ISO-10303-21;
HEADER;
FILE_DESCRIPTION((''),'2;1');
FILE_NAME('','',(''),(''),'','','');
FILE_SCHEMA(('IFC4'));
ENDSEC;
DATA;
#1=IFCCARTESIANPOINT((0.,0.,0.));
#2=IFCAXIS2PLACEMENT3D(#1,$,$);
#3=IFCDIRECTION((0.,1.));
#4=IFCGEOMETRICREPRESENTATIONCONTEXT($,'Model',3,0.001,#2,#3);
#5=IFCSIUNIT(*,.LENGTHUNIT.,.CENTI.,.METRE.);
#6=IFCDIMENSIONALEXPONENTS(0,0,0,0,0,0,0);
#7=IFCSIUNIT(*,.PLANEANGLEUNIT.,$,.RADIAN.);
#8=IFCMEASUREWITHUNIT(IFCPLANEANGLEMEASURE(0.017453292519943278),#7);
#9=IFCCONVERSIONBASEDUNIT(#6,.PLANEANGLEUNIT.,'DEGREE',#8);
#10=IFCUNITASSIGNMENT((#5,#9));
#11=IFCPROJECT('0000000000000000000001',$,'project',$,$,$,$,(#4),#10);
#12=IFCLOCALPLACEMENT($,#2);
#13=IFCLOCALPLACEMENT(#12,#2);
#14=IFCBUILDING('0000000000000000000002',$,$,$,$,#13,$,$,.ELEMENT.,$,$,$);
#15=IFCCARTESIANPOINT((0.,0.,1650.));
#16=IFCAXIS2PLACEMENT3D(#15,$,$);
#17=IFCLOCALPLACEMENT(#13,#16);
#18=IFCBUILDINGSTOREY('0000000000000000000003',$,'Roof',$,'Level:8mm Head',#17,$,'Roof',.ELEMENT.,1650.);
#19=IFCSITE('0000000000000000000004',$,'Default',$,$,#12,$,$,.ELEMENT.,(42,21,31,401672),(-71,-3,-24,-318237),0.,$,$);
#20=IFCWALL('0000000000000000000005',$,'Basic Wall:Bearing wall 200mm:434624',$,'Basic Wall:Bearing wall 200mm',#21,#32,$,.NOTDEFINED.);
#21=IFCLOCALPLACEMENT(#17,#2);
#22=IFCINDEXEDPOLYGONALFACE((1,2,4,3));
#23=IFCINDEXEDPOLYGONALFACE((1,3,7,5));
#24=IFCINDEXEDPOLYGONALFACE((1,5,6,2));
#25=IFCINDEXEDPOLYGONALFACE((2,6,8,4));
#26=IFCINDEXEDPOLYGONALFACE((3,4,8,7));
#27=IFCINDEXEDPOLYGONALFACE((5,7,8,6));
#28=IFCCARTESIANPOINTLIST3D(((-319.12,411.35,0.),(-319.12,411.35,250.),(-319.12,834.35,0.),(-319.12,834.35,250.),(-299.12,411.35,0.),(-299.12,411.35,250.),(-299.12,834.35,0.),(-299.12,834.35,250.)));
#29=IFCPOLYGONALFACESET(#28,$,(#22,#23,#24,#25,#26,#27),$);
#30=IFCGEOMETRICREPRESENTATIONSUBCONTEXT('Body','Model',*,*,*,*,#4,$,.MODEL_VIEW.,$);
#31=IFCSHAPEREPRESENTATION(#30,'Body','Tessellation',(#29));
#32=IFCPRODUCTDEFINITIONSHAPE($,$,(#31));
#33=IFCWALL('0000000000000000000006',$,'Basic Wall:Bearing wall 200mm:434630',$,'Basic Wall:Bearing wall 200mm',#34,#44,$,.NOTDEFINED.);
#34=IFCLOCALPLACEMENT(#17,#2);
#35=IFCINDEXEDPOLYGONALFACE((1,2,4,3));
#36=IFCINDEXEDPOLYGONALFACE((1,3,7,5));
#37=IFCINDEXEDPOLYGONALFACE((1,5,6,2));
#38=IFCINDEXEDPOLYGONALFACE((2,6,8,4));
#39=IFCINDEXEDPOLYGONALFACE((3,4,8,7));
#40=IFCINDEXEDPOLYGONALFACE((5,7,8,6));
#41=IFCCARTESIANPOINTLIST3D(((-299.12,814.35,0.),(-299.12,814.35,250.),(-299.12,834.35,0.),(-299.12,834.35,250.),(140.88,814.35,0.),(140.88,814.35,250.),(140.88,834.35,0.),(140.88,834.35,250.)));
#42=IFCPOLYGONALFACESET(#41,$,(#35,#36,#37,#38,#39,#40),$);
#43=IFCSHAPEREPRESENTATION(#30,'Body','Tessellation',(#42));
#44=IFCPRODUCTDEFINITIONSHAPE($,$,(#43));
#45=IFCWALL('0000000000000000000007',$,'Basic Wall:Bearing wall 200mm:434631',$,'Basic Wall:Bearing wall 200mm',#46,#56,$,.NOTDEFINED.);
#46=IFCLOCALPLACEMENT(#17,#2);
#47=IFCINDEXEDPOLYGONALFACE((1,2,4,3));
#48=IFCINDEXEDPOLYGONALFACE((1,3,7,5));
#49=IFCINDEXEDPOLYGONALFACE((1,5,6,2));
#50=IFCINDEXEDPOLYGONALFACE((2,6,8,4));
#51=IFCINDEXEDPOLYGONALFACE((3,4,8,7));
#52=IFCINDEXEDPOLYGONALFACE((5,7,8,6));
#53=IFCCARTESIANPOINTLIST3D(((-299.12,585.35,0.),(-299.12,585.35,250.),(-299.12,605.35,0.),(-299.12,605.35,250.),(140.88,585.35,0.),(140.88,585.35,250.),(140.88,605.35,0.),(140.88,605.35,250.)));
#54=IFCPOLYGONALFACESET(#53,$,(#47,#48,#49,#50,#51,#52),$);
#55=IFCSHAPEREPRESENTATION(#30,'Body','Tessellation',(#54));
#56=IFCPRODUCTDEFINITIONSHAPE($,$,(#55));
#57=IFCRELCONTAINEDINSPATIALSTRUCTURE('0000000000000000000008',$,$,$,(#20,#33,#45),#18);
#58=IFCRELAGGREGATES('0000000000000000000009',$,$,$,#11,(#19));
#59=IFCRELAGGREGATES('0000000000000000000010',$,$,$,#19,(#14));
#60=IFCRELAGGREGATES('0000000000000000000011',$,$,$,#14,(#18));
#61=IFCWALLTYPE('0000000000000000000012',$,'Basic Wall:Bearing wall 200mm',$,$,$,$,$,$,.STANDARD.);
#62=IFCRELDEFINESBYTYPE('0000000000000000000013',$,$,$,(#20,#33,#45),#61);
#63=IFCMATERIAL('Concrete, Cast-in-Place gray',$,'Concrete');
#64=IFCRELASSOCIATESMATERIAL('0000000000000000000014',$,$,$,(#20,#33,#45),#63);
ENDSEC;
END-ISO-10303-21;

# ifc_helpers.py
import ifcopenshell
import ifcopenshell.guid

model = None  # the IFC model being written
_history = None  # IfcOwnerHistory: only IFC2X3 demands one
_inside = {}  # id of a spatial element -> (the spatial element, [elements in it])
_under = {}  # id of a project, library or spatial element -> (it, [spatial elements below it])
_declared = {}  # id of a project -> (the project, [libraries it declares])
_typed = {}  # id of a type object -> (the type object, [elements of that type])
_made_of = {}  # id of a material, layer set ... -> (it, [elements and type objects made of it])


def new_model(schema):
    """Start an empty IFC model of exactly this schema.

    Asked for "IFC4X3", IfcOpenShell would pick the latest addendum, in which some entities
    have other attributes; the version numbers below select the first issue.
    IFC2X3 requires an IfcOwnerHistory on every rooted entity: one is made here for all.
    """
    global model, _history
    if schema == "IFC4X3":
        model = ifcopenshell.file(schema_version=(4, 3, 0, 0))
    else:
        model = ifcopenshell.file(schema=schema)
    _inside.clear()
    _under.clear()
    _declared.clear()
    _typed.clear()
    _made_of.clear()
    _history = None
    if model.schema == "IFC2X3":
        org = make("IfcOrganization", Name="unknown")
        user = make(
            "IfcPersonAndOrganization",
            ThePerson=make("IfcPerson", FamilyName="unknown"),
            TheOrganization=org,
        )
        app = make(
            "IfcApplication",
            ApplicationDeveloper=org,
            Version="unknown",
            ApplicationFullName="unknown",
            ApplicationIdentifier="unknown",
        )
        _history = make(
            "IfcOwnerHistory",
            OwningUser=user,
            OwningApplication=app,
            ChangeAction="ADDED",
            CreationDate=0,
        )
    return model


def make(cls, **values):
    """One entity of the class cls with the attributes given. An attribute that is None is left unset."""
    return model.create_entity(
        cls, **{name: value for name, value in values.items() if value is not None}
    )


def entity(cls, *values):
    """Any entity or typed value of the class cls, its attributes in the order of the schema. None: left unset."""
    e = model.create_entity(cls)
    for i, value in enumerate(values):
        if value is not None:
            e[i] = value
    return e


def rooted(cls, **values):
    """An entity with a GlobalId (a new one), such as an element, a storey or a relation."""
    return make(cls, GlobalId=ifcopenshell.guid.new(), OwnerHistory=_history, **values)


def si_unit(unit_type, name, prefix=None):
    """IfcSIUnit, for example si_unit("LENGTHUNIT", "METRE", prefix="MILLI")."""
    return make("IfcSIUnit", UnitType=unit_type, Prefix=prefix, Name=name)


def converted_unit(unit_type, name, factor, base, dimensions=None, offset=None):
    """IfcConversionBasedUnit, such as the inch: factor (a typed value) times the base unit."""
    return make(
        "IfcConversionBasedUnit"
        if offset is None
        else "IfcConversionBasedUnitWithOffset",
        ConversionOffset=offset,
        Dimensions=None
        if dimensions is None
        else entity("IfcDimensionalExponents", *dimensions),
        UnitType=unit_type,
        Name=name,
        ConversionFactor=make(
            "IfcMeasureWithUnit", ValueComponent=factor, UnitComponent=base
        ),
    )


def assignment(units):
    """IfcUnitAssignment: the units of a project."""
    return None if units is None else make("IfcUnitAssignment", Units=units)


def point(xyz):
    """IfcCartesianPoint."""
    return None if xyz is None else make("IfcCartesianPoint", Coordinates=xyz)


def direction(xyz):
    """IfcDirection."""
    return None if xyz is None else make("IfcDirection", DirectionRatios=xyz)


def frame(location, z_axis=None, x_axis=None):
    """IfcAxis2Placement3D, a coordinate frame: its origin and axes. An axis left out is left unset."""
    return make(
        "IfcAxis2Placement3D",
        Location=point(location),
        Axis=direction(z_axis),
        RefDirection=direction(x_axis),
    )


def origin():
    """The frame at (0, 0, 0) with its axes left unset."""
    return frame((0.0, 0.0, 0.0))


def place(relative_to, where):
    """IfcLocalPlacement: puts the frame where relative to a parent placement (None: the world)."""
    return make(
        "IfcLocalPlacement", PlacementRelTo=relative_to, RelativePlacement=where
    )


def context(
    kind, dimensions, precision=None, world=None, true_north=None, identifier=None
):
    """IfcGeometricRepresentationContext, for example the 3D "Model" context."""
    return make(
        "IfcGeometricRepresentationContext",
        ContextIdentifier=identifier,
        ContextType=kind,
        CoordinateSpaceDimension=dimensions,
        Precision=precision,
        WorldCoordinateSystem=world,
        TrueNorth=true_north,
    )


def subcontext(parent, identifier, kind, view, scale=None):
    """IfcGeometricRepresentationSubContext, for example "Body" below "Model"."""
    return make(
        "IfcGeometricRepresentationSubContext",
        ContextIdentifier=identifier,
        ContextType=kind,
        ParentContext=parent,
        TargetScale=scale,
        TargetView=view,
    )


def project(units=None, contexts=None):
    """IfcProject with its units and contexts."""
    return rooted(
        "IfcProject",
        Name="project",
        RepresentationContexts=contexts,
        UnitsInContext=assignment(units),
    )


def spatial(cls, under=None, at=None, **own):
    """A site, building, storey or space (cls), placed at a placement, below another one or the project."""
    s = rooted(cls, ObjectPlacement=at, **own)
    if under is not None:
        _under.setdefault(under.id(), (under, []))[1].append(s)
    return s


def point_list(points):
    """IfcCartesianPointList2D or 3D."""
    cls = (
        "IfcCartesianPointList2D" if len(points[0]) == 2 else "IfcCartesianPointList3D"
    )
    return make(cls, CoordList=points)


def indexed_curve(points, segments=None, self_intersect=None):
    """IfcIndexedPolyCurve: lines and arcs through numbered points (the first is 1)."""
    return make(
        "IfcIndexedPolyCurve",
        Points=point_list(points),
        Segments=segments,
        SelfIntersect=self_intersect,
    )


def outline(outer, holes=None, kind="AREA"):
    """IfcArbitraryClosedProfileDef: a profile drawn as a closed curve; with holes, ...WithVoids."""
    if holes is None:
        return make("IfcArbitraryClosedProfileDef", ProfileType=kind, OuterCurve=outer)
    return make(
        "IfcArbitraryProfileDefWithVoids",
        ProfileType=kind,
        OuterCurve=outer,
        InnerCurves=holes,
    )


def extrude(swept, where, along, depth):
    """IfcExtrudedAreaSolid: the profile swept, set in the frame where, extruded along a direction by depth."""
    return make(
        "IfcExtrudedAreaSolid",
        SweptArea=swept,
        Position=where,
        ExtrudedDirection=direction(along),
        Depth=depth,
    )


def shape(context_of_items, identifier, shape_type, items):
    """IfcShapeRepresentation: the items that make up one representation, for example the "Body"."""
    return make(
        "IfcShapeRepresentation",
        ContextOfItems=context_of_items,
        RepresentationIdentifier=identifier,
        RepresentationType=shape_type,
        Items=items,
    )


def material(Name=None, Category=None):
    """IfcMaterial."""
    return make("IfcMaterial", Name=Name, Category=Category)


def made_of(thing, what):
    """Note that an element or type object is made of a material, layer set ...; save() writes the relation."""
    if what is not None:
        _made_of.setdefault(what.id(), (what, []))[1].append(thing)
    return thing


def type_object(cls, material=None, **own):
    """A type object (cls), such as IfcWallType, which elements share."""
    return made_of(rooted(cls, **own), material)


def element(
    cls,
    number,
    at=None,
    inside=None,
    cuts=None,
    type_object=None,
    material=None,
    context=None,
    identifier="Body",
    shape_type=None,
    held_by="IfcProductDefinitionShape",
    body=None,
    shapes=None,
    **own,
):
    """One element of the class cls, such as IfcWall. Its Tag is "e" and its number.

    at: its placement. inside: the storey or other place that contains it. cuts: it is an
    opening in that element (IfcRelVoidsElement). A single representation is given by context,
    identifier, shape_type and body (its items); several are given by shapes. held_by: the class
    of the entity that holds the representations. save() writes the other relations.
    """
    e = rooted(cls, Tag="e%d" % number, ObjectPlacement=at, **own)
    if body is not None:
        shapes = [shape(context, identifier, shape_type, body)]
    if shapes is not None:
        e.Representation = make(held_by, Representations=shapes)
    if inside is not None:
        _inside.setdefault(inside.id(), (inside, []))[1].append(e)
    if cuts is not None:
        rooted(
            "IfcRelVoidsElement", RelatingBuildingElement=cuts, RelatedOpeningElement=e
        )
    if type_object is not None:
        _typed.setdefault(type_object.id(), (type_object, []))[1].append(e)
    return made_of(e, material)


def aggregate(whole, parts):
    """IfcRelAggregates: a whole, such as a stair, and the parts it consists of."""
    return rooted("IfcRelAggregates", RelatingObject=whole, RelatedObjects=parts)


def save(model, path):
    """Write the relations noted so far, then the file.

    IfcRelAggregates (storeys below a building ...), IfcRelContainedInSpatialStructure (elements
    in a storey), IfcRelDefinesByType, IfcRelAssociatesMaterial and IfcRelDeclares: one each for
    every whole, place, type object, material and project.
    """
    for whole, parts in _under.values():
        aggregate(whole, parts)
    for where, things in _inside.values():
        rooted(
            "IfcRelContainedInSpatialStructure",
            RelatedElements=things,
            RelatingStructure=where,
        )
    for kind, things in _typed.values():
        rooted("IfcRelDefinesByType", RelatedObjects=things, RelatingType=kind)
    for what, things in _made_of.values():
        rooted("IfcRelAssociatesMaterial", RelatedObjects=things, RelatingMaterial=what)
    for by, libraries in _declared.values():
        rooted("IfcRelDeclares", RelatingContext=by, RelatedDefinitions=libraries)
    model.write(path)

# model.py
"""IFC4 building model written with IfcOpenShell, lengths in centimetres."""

from ifc_helpers import new_model, entity, si_unit, converted_unit, direction, frame, origin, place, context, subcontext, project, spatial, indexed_curve, outline, extrude, material, type_object, element, save


model = new_model("IFC4")

# Units and contexts
model_context = context("Model", 3, precision=0.001, world=origin(), true_north=direction((0.0, 1.0)))
body_context = subcontext(model_context, "Body", "Model", "MODEL_VIEW")
ifc_project = project(units=[si_unit("LENGTHUNIT", "METRE", prefix="CENTI"), converted_unit("PLANEANGLEUNIT", "DEGREE", entity("IfcPlaneAngleMeasure", 0.017453292519943278), si_unit("PLANEANGLEUNIT", "RADIAN"), dimensions=[0, 0, 0, 0, 0, 0, 0])], contexts=[model_context])

# Site, building, storey
site_placement = place(None, origin())
site = spatial("IfcSite", under=ifc_project, at=site_placement, Name="Default", CompositionType="ELEMENT", RefLatitude=(42, 21, 31, 401672), RefLongitude=(-71, -3, -24, -318237), RefElevation=0.0)
building_placement = place(site_placement, origin())
building = spatial("IfcBuilding", under=site, at=building_placement, CompositionType="ELEMENT")
storey_placement = place(building_placement, frame((0.0, 0.0, 1650.0)))
storey = spatial("IfcBuildingStorey", under=building, at=storey_placement, Name="Roof", ObjectType="Level:8mm Head", LongName="Roof", CompositionType="ELEMENT", Elevation=1650.0)

# Shared definitions
ifc_material_1 = material(Name="Concrete, Cast-in-Place gray", Category="Concrete")

# Walls
wall_type = type_object("IfcWallType", Name="Basic Wall:Bearing wall 200mm", PredefinedType="STANDARD")
wall_1_placement = place(storey_placement, frame((-309.12, 834.35, 0.0), z_axis=(0.0, 0.0, 1.0), x_axis=(0.0, -1.0, 0.0)))
element("IfcWall", 1, at=wall_1_placement, inside=storey, type_object=wall_type, material=ifc_material_1, Name="Basic Wall:Bearing wall 200mm:434624", ObjectType="Basic Wall:Bearing wall 200mm", PredefinedType="NOTDEFINED", context=body_context, shape_type="SweptSolid", body=[
    extrude(outline(indexed_curve([(423.0, 10.0), (0.0, 10.0), (0.0, -10.0), (423.0, -10.0), (423.0, 10.0)], self_intersect=False)), origin(), (0.0, 0.0, 1.0), 250.0),
])
wall_2_placement = place(storey_placement, frame((140.88, 824.35, 0.0), z_axis=(0.0, 0.0, 1.0), x_axis=(-1.0, 0.0, 0.0)))
element("IfcWall", 2, at=wall_2_placement, inside=storey, type_object=wall_type, material=ifc_material_1, Name="Basic Wall:Bearing wall 200mm:434630", ObjectType="Basic Wall:Bearing wall 200mm", PredefinedType="NOTDEFINED", context=body_context, shape_type="SweptSolid", body=[
    extrude(outline(indexed_curve([(440.0, 10.0), (0.0, 10.0), (0.0, -10.0), (440.0, -10.0), (440.0, 10.0)], self_intersect=False)), origin(), (0.0, 0.0, 1.0), 250.0),
])
wall_3_placement = place(storey_placement, frame((-299.12, 595.35, 0.0)))
element("IfcWall", 3, at=wall_3_placement, inside=storey, type_object=wall_type, material=ifc_material_1, Name="Basic Wall:Bearing wall 200mm:434631", ObjectType="Basic Wall:Bearing wall 200mm", PredefinedType="NOTDEFINED", context=body_context, shape_type="SweptSolid", body=[
    extrude(outline(indexed_curve([(440.0, 10.0), (0.0, 10.0), (0.0, -10.0), (440.0, -10.0), (440.0, 10.0)], self_intersect=False)), origin(), (0.0, 0.0, 1.0), 250.0),
])

save(model, "model.ifc")
